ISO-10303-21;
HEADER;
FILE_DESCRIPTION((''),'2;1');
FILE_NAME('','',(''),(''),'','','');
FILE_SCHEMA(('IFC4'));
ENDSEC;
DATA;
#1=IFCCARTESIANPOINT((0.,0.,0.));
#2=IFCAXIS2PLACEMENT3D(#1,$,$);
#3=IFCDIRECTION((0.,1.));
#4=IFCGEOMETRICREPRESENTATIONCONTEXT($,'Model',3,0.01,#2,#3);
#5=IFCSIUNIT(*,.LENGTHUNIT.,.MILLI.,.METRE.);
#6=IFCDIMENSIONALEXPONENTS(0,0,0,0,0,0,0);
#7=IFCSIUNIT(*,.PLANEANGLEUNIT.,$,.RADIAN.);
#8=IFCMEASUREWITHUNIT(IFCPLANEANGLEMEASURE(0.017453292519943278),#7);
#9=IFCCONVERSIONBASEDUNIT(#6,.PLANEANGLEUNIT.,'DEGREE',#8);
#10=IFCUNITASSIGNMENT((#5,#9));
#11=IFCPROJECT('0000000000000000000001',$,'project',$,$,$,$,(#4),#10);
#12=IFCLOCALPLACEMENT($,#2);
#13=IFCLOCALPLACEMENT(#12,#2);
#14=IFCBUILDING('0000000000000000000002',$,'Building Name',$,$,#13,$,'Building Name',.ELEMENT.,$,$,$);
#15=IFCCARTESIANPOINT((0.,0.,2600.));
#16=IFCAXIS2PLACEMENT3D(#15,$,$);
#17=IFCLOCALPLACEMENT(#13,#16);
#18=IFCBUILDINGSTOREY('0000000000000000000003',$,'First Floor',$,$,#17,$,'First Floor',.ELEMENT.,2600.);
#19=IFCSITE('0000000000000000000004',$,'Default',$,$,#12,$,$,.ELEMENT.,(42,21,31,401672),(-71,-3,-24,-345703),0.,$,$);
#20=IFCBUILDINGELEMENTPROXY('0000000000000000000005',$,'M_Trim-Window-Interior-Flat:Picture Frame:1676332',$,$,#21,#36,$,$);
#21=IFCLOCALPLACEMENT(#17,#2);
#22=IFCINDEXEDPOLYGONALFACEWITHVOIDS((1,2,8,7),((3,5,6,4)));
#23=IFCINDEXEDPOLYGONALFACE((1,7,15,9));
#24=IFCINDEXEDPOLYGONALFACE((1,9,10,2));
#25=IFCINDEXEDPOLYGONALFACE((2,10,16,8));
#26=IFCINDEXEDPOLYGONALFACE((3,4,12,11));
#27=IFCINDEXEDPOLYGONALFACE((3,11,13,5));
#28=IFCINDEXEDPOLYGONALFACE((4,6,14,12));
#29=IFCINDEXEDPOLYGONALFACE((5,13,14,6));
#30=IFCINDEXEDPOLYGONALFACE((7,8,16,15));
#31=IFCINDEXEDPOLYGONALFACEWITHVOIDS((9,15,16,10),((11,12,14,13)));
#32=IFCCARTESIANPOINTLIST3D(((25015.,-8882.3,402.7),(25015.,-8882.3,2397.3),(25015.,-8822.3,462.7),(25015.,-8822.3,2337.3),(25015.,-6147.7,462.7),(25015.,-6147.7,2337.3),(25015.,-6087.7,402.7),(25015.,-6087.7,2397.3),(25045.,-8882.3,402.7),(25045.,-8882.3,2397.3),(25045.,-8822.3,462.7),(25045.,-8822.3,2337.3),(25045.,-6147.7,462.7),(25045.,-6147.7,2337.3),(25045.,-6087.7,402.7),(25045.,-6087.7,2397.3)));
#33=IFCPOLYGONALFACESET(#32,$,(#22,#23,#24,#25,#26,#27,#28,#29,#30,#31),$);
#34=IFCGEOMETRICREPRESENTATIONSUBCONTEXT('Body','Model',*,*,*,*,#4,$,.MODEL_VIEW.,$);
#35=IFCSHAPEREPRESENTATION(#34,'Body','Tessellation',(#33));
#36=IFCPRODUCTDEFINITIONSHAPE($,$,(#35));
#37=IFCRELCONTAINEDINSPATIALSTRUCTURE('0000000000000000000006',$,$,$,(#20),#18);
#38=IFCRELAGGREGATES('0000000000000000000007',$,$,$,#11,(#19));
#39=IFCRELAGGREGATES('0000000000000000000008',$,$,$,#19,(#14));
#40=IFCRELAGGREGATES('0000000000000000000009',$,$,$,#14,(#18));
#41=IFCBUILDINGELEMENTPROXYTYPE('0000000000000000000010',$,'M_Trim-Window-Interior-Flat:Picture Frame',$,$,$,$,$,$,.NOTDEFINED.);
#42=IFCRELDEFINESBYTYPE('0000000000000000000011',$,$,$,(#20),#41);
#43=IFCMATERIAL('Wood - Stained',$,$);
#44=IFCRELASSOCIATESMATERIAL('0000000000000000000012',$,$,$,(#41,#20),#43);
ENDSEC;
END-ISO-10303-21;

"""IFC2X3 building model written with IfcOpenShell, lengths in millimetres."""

from ifc_helpers import new_model, entity, si_unit, converted_unit, direction, frame, origin, place, context, subcontext, project, spatial, polyline, outline, extrude, source, transform, mapped, material, type_object, type_shapes, element, save


model = new_model("IFC2X3")

# Units and contexts
model_context = context("Model", 3, precision=0.01, world=origin(), true_north=direction((0.0, 1.0)))
body_context = subcontext(model_context, "Body", "Model", "MODEL_VIEW")
ifc_project = project(units=[si_unit("LENGTHUNIT", "METRE", prefix="MILLI"), converted_unit("PLANEANGLEUNIT", "DEGREE", entity("IfcPlaneAngleMeasure", 0.017453292519943278), si_unit("PLANEANGLEUNIT", "RADIAN"), dimensions=[0, 0, 0, 0, 0, 0, 0])], contexts=[model_context])

# Site, building, storey
site_placement = place(None, origin())
site = spatial("IfcSite", under=ifc_project, at=site_placement, Name="Default", CompositionType="ELEMENT", RefLatitude=(42, 21, 31, 401672), RefLongitude=(-71, -3, -24, -345703), RefElevation=0.0)
building_placement = place(site_placement, origin())
building = spatial("IfcBuilding", under=site, at=building_placement, Name="Building Name", LongName="Building Name", CompositionType="ELEMENT")
storey_placement = place(building_placement, frame((0.0, 0.0, 2600.0)))
storey = spatial("IfcBuildingStorey", under=building, at=storey_placement, Name="First Floor", LongName="First Floor", CompositionType="ELEMENT", Elevation=2600.0)

# Building element proxy
ifc_material_1 = material(Name="Wood - Stained")
building_element_proxy_type_1 = type_object("IfcBuildingElementProxyType", Name="M_Trim-Window-Interior-Flat:Picture Frame", PredefinedType="NOTDEFINED", material=ifc_material_1)
shared_shape_1 = source(origin(), body_context, "Body", "SweptSolid", [
    extrude(outline(polyline([(-1397.3, -997.3), (1397.3, -997.3), (1397.3, 997.3), (-1397.3, 997.3), (-1397.3, -997.3)]), holes=[polyline([(-1337.3, -937.3), (-1337.3, 937.3), (1337.3, 937.3), (1337.3, -937.3), (-1337.3, -937.3)])]), frame((0.0, -950.0, 0.0), z_axis=(0.0, 0.0, 1.0), x_axis=(-1.0, 0.0, 0.0)), (0.0, 0.0, 1.0), 30.0),
])
type_shapes(building_element_proxy_type_1, [shared_shape_1])
proxy_1_placement = place(storey_placement, frame((25015.0, -7485.0, 2350.0), z_axis=(1.0, 0.0, 0.0), x_axis=(0.0, 1.0, 0.0)))
element("IfcBuildingElementProxy", 1, at=proxy_1_placement, inside=storey, type_object=building_element_proxy_type_1, material=ifc_material_1, Name="M_Trim-Window-Interior-Flat:Picture Frame:1676332", context=body_context, shape_type="MappedRepresentation", body=[
    mapped(shared_shape_1, transform((0.0, 0.0, 0.0), scale=1.0)),
])

save(model, "model.ifc")
